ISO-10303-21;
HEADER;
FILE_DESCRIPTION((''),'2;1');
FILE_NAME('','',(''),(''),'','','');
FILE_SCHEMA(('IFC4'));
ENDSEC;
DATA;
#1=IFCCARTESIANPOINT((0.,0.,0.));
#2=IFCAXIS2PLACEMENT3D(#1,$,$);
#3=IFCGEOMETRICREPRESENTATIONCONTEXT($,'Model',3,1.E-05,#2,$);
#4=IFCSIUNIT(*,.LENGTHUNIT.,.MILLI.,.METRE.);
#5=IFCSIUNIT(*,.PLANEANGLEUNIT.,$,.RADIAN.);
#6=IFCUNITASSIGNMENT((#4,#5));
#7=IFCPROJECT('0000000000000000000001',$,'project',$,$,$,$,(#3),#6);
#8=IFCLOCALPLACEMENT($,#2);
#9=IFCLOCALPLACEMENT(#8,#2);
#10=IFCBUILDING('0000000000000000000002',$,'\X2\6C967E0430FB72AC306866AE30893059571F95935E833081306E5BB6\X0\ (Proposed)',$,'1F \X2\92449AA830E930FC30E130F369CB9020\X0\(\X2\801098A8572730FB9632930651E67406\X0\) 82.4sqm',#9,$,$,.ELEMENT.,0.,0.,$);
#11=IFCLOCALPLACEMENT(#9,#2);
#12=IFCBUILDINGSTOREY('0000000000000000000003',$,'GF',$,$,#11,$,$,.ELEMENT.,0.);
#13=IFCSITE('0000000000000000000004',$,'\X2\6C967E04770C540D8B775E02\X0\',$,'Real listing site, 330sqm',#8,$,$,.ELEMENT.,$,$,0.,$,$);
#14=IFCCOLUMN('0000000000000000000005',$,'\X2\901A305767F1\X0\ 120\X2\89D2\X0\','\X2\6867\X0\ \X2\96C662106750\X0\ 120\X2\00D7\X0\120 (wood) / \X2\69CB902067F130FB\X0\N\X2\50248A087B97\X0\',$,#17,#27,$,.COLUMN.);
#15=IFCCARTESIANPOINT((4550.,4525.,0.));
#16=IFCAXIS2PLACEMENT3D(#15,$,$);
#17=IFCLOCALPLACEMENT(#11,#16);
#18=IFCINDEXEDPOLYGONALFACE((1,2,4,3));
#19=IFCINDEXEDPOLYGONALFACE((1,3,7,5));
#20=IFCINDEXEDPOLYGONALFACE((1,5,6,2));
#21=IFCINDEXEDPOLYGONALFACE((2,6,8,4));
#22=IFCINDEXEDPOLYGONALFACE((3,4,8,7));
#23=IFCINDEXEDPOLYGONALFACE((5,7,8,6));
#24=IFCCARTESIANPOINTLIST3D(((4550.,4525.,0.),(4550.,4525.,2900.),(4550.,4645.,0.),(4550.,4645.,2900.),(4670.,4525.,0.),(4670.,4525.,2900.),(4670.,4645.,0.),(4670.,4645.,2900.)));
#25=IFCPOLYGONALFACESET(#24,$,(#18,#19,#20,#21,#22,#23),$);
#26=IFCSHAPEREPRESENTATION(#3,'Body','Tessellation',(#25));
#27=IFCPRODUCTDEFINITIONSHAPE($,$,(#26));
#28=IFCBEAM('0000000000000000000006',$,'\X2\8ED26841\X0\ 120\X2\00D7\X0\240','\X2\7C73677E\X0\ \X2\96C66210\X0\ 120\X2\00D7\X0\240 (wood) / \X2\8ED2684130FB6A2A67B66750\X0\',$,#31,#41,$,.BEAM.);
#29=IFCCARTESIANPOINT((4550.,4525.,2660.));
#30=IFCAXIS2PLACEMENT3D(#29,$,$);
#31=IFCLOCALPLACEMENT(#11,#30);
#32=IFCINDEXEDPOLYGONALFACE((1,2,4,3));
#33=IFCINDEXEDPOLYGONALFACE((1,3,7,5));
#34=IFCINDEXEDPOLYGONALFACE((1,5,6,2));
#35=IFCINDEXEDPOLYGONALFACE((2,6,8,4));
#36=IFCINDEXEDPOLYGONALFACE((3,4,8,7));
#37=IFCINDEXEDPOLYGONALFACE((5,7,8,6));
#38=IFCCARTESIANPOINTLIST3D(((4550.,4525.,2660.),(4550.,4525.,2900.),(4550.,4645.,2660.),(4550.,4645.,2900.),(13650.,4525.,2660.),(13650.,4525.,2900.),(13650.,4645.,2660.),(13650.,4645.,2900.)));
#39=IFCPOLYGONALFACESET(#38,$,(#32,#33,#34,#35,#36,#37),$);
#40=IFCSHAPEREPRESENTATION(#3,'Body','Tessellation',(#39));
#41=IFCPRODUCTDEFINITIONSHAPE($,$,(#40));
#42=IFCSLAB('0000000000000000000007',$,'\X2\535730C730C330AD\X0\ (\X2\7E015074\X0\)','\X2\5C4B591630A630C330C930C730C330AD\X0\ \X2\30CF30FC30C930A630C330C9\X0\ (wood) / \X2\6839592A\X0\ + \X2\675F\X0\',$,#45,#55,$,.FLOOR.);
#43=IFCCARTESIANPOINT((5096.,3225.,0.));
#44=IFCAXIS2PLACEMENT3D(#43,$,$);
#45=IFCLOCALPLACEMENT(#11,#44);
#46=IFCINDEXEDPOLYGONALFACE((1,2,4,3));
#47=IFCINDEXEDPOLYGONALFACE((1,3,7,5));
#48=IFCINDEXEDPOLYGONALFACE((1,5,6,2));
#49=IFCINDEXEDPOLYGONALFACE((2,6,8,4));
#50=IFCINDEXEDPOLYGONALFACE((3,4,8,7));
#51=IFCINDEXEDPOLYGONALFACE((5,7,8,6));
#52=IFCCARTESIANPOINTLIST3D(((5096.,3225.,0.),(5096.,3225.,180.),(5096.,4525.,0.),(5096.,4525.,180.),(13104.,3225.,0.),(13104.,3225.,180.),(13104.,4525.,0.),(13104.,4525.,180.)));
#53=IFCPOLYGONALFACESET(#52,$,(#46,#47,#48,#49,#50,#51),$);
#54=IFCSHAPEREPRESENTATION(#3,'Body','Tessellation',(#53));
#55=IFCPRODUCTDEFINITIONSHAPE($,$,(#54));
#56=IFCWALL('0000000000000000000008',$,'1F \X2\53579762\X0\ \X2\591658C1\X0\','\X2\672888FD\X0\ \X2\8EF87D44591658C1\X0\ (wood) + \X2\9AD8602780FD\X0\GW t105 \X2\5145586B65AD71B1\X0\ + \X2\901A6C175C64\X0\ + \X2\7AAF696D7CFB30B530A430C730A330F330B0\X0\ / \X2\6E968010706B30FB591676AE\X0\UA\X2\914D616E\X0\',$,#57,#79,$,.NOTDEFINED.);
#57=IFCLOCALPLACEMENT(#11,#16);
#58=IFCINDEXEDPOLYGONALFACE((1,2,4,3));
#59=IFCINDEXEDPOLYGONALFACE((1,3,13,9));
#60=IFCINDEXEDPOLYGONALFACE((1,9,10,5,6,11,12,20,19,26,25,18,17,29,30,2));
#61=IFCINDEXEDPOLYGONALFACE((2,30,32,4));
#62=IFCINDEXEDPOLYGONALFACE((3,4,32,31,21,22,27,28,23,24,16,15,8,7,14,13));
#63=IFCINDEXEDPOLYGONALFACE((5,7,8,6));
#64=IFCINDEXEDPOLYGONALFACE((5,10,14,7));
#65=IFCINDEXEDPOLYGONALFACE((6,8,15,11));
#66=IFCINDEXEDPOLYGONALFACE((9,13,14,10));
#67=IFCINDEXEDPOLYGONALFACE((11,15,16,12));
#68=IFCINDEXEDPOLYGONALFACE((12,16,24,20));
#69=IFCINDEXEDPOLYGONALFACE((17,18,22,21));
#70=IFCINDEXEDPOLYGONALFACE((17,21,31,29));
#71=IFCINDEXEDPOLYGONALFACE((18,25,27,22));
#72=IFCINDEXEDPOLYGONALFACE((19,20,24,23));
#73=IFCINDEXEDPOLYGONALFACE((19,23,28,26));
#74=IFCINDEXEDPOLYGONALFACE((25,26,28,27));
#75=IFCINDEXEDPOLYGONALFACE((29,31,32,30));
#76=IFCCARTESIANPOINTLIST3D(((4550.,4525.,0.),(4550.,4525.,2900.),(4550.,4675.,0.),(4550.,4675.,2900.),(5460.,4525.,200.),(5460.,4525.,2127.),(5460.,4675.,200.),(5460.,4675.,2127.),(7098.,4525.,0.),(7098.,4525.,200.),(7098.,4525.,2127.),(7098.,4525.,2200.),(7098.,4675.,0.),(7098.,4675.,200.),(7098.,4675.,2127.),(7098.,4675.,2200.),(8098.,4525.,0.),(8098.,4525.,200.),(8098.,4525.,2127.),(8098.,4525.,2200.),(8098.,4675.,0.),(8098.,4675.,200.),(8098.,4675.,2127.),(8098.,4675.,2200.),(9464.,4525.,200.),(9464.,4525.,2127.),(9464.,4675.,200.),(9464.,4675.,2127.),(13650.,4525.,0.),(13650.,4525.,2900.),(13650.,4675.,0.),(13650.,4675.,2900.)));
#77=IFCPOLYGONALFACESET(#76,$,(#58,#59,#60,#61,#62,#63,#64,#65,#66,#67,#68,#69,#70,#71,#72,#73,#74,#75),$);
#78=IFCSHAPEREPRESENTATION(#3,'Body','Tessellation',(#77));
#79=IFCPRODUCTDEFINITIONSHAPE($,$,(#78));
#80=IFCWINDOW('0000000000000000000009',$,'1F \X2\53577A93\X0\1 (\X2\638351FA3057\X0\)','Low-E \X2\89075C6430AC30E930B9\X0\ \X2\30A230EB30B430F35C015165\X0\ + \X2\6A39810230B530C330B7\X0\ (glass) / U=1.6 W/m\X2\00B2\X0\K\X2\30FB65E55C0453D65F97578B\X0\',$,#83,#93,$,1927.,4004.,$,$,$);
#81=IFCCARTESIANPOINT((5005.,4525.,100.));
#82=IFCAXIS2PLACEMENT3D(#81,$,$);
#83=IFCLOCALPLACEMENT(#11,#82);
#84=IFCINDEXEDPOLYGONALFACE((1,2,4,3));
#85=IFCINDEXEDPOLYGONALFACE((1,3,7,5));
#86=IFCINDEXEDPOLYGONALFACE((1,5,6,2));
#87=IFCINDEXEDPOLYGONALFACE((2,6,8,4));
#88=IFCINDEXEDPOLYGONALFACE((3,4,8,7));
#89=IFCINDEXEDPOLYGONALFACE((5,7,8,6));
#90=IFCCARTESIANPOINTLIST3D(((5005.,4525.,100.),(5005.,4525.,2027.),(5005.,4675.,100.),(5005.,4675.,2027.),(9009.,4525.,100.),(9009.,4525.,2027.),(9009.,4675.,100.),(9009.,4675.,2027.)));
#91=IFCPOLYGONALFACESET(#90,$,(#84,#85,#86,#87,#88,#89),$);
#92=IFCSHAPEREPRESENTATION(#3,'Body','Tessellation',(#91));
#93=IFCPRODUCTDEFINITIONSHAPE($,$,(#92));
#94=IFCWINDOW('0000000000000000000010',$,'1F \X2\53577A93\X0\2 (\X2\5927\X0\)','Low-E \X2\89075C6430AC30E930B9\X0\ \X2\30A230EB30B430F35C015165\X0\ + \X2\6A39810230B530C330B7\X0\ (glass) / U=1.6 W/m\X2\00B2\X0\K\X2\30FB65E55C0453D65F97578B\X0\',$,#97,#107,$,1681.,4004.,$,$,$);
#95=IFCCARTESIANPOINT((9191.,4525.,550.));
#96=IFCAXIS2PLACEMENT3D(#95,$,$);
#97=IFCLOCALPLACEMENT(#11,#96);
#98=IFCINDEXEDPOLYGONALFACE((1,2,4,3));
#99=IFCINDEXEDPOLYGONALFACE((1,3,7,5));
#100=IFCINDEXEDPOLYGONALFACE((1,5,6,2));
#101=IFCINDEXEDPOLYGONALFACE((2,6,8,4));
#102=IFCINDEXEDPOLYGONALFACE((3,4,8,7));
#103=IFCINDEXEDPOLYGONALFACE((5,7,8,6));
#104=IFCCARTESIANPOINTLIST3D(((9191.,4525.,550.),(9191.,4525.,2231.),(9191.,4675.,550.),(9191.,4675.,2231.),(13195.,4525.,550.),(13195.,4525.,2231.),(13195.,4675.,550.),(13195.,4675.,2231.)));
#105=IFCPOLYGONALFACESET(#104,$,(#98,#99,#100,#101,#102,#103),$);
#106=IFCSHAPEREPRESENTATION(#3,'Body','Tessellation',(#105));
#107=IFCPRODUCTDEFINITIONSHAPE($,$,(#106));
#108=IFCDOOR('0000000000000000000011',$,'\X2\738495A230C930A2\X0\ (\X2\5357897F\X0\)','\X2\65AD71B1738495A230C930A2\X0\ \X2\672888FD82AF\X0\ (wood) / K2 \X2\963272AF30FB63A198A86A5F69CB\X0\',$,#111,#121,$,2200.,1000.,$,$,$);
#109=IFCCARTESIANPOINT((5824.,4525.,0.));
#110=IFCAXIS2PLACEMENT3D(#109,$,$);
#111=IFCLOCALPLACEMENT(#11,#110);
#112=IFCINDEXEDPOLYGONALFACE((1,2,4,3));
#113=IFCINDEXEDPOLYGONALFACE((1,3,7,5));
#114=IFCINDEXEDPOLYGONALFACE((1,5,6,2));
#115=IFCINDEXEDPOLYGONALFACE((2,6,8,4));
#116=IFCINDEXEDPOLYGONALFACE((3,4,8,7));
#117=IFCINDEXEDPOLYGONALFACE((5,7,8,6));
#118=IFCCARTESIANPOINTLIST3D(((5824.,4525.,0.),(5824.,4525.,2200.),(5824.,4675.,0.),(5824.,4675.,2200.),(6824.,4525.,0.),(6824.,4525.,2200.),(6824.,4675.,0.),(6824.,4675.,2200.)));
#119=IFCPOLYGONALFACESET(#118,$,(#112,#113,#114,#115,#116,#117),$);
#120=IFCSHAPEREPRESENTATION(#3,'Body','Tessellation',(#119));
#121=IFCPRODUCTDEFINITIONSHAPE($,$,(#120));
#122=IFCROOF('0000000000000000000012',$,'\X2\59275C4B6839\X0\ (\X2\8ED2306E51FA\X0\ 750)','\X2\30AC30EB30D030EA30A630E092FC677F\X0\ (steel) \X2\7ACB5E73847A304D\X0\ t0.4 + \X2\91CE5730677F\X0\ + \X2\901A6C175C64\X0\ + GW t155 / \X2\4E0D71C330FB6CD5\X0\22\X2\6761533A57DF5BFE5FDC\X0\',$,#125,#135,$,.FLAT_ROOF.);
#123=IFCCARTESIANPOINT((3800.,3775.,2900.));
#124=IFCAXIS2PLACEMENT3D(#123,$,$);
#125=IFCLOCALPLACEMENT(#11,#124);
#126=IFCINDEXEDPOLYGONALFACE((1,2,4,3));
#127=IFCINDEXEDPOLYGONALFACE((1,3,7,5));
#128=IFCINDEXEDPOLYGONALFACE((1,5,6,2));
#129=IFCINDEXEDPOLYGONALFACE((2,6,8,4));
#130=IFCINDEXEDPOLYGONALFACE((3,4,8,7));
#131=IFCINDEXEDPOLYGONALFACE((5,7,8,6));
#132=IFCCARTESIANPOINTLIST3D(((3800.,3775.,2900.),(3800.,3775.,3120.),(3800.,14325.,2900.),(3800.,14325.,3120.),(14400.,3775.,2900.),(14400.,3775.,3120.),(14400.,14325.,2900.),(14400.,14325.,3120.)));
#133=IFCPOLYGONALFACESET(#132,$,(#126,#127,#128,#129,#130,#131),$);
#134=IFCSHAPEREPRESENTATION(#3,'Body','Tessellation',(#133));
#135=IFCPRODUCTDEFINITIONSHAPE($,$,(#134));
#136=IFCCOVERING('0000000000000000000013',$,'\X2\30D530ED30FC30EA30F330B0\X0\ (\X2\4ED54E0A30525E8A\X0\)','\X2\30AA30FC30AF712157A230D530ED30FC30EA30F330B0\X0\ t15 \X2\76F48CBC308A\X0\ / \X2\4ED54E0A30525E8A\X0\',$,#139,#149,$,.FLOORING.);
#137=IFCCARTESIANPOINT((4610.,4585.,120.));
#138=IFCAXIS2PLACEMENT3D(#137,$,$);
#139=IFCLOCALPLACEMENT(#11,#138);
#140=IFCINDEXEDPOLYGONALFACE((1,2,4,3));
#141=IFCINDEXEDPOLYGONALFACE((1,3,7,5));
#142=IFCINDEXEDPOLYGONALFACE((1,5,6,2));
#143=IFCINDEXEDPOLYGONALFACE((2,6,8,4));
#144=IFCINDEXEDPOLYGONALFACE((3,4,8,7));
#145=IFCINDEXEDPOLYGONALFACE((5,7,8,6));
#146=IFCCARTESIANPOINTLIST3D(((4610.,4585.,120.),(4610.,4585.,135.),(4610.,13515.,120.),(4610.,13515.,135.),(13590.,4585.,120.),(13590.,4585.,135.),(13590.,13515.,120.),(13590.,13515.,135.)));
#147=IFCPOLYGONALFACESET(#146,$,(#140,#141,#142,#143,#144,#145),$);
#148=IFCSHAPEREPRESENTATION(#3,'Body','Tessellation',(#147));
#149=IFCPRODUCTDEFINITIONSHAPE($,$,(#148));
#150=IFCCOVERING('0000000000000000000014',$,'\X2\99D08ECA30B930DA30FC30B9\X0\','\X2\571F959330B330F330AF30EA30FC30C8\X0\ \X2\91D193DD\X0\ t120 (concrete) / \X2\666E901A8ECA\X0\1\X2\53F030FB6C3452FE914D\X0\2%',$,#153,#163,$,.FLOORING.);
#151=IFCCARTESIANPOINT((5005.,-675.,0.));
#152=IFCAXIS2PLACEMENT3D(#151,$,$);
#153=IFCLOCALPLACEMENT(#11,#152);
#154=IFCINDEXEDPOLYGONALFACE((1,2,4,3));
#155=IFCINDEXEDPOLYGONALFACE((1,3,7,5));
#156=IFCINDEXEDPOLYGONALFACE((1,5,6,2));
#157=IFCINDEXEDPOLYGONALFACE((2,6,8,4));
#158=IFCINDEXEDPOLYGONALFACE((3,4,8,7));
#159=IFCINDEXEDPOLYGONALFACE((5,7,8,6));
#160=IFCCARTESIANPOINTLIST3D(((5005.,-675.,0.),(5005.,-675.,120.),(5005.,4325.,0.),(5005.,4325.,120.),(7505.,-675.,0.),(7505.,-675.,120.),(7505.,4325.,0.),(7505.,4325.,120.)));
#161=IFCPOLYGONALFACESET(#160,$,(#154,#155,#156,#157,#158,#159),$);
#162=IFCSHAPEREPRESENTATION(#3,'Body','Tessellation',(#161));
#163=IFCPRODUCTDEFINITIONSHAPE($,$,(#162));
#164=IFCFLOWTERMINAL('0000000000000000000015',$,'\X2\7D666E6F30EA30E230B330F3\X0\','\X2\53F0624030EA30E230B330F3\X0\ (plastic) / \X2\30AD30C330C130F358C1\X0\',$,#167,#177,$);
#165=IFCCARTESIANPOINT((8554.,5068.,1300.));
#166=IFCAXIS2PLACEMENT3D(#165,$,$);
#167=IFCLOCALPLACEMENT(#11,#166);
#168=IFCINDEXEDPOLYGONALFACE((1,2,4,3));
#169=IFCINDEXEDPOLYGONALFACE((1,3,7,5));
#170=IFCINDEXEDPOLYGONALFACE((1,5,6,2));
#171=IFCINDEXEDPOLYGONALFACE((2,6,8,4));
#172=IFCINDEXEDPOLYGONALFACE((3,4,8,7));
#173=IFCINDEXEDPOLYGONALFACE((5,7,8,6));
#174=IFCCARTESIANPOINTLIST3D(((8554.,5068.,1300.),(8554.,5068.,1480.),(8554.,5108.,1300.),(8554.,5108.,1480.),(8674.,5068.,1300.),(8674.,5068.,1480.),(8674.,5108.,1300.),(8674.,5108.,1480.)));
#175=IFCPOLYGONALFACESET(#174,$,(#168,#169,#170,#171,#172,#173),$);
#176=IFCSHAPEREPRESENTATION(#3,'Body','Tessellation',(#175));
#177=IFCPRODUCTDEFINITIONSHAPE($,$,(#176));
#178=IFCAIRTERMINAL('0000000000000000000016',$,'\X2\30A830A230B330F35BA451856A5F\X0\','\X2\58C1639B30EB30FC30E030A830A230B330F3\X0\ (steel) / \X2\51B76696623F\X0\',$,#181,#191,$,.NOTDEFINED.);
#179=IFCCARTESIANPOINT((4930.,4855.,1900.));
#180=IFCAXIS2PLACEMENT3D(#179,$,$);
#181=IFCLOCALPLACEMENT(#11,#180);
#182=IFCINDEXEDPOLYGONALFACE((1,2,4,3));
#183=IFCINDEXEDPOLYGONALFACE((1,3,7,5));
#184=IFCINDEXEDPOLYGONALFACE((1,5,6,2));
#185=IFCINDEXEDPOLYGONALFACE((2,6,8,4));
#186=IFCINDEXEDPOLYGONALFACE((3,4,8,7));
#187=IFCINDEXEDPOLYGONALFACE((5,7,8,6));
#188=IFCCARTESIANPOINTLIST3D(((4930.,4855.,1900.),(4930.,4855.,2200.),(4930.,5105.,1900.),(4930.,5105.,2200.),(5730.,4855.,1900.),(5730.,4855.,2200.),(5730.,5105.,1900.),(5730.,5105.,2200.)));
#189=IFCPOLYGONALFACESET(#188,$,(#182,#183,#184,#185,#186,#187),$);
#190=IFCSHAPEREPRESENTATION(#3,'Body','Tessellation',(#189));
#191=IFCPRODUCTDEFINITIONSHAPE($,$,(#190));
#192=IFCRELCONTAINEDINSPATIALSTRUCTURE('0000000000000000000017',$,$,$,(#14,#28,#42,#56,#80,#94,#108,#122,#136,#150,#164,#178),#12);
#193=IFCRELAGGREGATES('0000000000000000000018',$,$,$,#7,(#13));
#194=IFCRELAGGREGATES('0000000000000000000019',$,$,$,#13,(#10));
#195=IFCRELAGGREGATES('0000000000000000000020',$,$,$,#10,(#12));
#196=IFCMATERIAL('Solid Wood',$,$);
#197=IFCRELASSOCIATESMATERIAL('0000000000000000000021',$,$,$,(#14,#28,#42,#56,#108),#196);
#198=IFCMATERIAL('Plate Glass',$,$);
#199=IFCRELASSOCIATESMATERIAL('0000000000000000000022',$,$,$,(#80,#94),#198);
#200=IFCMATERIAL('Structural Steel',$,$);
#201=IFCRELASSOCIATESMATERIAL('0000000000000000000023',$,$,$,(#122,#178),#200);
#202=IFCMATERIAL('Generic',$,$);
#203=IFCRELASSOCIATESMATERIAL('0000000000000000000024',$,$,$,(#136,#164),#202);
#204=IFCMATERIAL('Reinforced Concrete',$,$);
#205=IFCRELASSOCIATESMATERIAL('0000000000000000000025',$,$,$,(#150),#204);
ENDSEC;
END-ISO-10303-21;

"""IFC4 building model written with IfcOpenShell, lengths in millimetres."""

from ifc_helpers import new_model, si_unit, frame, frame_2d, origin, place, context, project, spatial, rectangle, extrude, material, element, fill, save


model = new_model("IFC4")

# Units and contexts
model_context = context("Model", 3, precision=1e-05, world=origin())
ifc_project = project(units=[si_unit("LENGTHUNIT", "METRE", prefix="MILLI"), si_unit("PLANEANGLEUNIT", "RADIAN")], contexts=[model_context])

# Site, building, storey
site_placement = place(None, origin())
site = spatial("IfcSite", under=ifc_project, at=site_placement, Name="沖縄県名護市", ObjectType="Real listing site, 330sqm", CompositionType="ELEMENT", RefElevation=0.0)
building_placement = place(site_placement, origin())
building = spatial("IfcBuilding", under=site, at=building_placement, Name="沖縄・犬と暮らす土間広めの家 (Proposed)", ObjectType="1F 鉄骨ラーメン構造(耐風圧・防錆処理) 82.4sqm", CompositionType="ELEMENT", ElevationOfRefHeight=0.0, ElevationOfTerrain=0.0)
storey_placement = place(building_placement, origin())
storey = spatial("IfcBuildingStorey", under=building, at=storey_placement, Name="GF", CompositionType="ELEMENT", Elevation=0.0)

# Column
ifc_material_1 = material(Name="Solid Wood")
column_1_placement = place(storey_placement, frame((4550.0, 4525.0, 0.0)))
element("IfcColumn", 1, at=column_1_placement, inside=storey, material=ifc_material_1, Name="通し柱 120角", Description="桧 集成材 120×120 (wood) / 構造柱・N値計算", PredefinedType="COLUMN", context=model_context, shape_type="SweptSolid", body=[
    extrude(rectangle(XDim=120.0, YDim=120.0, at=frame_2d((60.0, 60.0))), frame((4550.0, 4525.0, 0.0)), (0.0, 0.0, 1.0), 2900.0),
])

# Beam
beam_1_placement = place(storey_placement, frame((4550.0, 4525.0, 2660.0)))
element("IfcBeam", 2, at=beam_1_placement, inside=storey, material=ifc_material_1, Name="軒桁 120×240", Description="米松 集成 120×240 (wood) / 軒桁・横架材", PredefinedType="BEAM", context=model_context, shape_type="SweptSolid", body=[
    extrude(rectangle(XDim=9100.0, YDim=120.0, at=frame_2d((4550.0, 60.0))), frame((4550.0, 4525.0, 2660.0)), (0.0, 0.0, 1.0), 240.0),
])

# Slab
ifc_material_2 = material(Name="Reinforced Concrete")
slab_1_placement = place(storey_placement, frame((5096.0, 3225.0, 0.0)))
element("IfcSlab", 3, at=slab_1_placement, inside=storey, material=ifc_material_1, Name="南デッキ (縁側)", Description="屋外ウッドデッキ ハードウッド (wood) / 根太 + 束", PredefinedType="FLOOR", context=model_context, shape_type="SweptSolid", body=[
    extrude(rectangle(XDim=8008.0, YDim=1300.0, at=frame_2d((4004.0, 650.0))), frame((5096.0, 3225.0, 0.0)), (0.0, 0.0, 1.0), 180.0),
])

# Wall, openings, windows, door
wall_1_placement = place(storey_placement, frame((4550.0, 4525.0, 0.0)))
wall_1 = element("IfcWall", 4, at=wall_1_placement, inside=storey, material=ifc_material_1, Name="1F 南面 外壁", Description="木製 軸組外壁 (wood) + 高性能GW t105 充填断熱 + 通気層 + 窯業系サイディング / 準耐火・外皮UA配慮", PredefinedType="NOTDEFINED", context=model_context, shape_type="SweptSolid", body=[
    extrude(rectangle(XDim=9100.0, YDim=150.0, at=frame_2d((4550.0, 75.0))), frame((4550.0, 4525.0, 0.0)), (0.0, 0.0, 1.0), 2900.0),
])
opening_1_placement = place(storey_placement, frame((5005.0, 4525.0, 100.0)))
opening_1 = element("IfcOpeningElement", 5, at=opening_1_placement, cuts=wall_1, PredefinedType="NOTDEFINED", context=model_context, shape_type="SweptSolid", body=[
    extrude(rectangle(XDim=4004.0, YDim=150.0, at=frame_2d((2002.0, 75.0))), frame((5005.0, 4525.0, 100.0)), (0.0, 0.0, 1.0), 1927.0),
])
opening_2_placement = place(storey_placement, frame((9191.0, 4525.0, 550.0)))
opening_2 = element("IfcOpeningElement", 6, at=opening_2_placement, cuts=wall_1, PredefinedType="NOTDEFINED", context=model_context, shape_type="SweptSolid", body=[
    extrude(rectangle(XDim=4004.0, YDim=150.0, at=frame_2d((2002.0, 75.0))), frame((9191.0, 4525.0, 550.0)), (0.0, 0.0, 1.0), 1681.0),
])
opening_3_placement = place(storey_placement, frame((5824.0, 4525.0, 0.0)))
opening_3 = element("IfcOpeningElement", 7, at=opening_3_placement, cuts=wall_1, PredefinedType="NOTDEFINED", context=model_context, shape_type="SweptSolid", body=[
    extrude(rectangle(XDim=1000.0, YDim=150.0, at=frame_2d((500.0, 75.0))), frame((5824.0, 4525.0, 0.0)), (0.0, 0.0, 1.0), 2200.0),
])
ifc_material_3 = material(Name="Plate Glass")
window_1_placement = place(storey_placement, frame((5005.0, 4525.0, 100.0)))
window_1 = element("IfcWindow", 8, at=window_1_placement, inside=storey, material=ifc_material_3, Name="1F 南窓1 (掃出し)", Description="Low-E 複層ガラス アルゴン封入 + 樹脂サッシ (glass) / U=1.6 W/m²K・日射取得型", OverallHeight=1927.0, OverallWidth=4004.0, context=model_context, shape_type="SweptSolid", body=[
    extrude(rectangle(XDim=4004.0, YDim=150.0, at=frame_2d((2002.0, 75.0))), frame((5005.0, 4525.0, 100.0)), (0.0, 0.0, 1.0), 1927.0),
])
fill(opening_1, window_1)
window_2_placement = place(storey_placement, frame((9191.0, 4525.0, 550.0)))
window_2 = element("IfcWindow", 9, at=window_2_placement, inside=storey, material=ifc_material_3, Name="1F 南窓2 (大)", Description="Low-E 複層ガラス アルゴン封入 + 樹脂サッシ (glass) / U=1.6 W/m²K・日射取得型", OverallHeight=1681.0, OverallWidth=4004.0, context=model_context, shape_type="SweptSolid", body=[
    extrude(rectangle(XDim=4004.0, YDim=150.0, at=frame_2d((2002.0, 75.0))), frame((9191.0, 4525.0, 550.0)), (0.0, 0.0, 1.0), 1681.0),
])
fill(opening_2, window_2)
door_placement = place(storey_placement, frame((5824.0, 4525.0, 0.0)))
door = element("IfcDoor", 10, at=door_placement, inside=storey, material=ifc_material_1, Name="玄関ドア (南西)", Description="断熱玄関ドア 木製芯 (wood) / K2 防犯・採風機構", OverallHeight=2200.0, OverallWidth=1000.0, context=model_context, shape_type="SweptSolid", body=[
    extrude(rectangle(XDim=1000.0, YDim=150.0, at=frame_2d((500.0, 75.0))), frame((5824.0, 4525.0, 0.0)), (0.0, 0.0, 1.0), 2200.0),
])
fill(opening_3, door)

# Roof
ifc_material_4 = material(Name="Structural Steel")
roof_placement = place(storey_placement, frame((3800.0, 3775.0, 2900.0)))
element("IfcRoof", 11, at=roof_placement, inside=storey, material=ifc_material_4, Name="大屋根 (軒の出 750)", Description="ガルバリウム鋼板 (steel) 立平葺き t0.4 + 野地板 + 通気層 + GW t155 / 不燃・法22条区域対応", PredefinedType="FLAT_ROOF", context=model_context, shape_type="SweptSolid", body=[
    extrude(rectangle(XDim=10600.0, YDim=10550.0, at=frame_2d((5300.0, 5275.0))), frame((3800.0, 3775.0, 2900.0)), (0.0, 0.0, 1.0), 220.0),
])

# Coverings
ifc_material_5 = material(Name="Generic")
covering_1_placement = place(storey_placement, frame((4610.0, 4585.0, 120.0)))
element("IfcCovering", 12, at=covering_1_placement, inside=storey, material=ifc_material_5, Name="フローリング (仕上げ床)", Description="オーク無垢フローリング t15 直貼り / 仕上げ床", PredefinedType="FLOORING", context=model_context, shape_type="SweptSolid", body=[
    extrude(rectangle(XDim=8980.0, YDim=8930.0, at=frame_2d((4490.0, 4465.0))), frame((4610.0, 4585.0, 120.0)), (0.0, 0.0, 1.0), 15.0),
])
covering_2_placement = place(storey_placement, frame((5005.0, -675.0, 0.0)))
element("IfcCovering", 13, at=covering_2_placement, inside=storey, material=ifc_material_2, Name="駐車スペース", Description="土間コンクリート 金鏝 t120 (concrete) / 普通車1台・水勾配2%", PredefinedType="FLOORING", context=model_context, shape_type="SweptSolid", body=[
    extrude(rectangle(XDim=2500.0, YDim=5000.0, at=frame_2d((1250.0, 2500.0))), frame((5005.0, -675.0, 0.0)), (0.0, 0.0, 1.0), 120.0),
])

# Flow terminal
flow_terminal_placement = place(storey_placement, frame((8554.0, 5068.0, 1300.0)))
element("IfcFlowTerminal", 14, at=flow_terminal_placement, inside=storey, material=ifc_material_5, Name="給湯リモコン", Description="台所リモコン (plastic) / キッチン壁", context=model_context, shape_type="SweptSolid", body=[
    extrude(rectangle(XDim=120.0, YDim=40.0, at=frame_2d((60.0, 20.0))), frame((8554.0, 5068.0, 1300.0)), (0.0, 0.0, 1.0), 180.0),
])

# Air terminal
air_terminal_placement = place(storey_placement, frame((4930.0, 4855.0, 1900.0)))
element("IfcAirTerminal", 15, at=air_terminal_placement, inside=storey, material=ifc_material_4, Name="エアコン室内機", Description="壁掛ルームエアコン (steel) / 冷暖房", PredefinedType="NOTDEFINED", context=model_context, shape_type="SweptSolid", body=[
    extrude(rectangle(XDim=800.0, YDim=250.0, at=frame_2d((400.0, 125.0))), frame((4930.0, 4855.0, 1900.0)), (0.0, 0.0, 1.0), 300.0),
])

save(model, "model.ifc")
